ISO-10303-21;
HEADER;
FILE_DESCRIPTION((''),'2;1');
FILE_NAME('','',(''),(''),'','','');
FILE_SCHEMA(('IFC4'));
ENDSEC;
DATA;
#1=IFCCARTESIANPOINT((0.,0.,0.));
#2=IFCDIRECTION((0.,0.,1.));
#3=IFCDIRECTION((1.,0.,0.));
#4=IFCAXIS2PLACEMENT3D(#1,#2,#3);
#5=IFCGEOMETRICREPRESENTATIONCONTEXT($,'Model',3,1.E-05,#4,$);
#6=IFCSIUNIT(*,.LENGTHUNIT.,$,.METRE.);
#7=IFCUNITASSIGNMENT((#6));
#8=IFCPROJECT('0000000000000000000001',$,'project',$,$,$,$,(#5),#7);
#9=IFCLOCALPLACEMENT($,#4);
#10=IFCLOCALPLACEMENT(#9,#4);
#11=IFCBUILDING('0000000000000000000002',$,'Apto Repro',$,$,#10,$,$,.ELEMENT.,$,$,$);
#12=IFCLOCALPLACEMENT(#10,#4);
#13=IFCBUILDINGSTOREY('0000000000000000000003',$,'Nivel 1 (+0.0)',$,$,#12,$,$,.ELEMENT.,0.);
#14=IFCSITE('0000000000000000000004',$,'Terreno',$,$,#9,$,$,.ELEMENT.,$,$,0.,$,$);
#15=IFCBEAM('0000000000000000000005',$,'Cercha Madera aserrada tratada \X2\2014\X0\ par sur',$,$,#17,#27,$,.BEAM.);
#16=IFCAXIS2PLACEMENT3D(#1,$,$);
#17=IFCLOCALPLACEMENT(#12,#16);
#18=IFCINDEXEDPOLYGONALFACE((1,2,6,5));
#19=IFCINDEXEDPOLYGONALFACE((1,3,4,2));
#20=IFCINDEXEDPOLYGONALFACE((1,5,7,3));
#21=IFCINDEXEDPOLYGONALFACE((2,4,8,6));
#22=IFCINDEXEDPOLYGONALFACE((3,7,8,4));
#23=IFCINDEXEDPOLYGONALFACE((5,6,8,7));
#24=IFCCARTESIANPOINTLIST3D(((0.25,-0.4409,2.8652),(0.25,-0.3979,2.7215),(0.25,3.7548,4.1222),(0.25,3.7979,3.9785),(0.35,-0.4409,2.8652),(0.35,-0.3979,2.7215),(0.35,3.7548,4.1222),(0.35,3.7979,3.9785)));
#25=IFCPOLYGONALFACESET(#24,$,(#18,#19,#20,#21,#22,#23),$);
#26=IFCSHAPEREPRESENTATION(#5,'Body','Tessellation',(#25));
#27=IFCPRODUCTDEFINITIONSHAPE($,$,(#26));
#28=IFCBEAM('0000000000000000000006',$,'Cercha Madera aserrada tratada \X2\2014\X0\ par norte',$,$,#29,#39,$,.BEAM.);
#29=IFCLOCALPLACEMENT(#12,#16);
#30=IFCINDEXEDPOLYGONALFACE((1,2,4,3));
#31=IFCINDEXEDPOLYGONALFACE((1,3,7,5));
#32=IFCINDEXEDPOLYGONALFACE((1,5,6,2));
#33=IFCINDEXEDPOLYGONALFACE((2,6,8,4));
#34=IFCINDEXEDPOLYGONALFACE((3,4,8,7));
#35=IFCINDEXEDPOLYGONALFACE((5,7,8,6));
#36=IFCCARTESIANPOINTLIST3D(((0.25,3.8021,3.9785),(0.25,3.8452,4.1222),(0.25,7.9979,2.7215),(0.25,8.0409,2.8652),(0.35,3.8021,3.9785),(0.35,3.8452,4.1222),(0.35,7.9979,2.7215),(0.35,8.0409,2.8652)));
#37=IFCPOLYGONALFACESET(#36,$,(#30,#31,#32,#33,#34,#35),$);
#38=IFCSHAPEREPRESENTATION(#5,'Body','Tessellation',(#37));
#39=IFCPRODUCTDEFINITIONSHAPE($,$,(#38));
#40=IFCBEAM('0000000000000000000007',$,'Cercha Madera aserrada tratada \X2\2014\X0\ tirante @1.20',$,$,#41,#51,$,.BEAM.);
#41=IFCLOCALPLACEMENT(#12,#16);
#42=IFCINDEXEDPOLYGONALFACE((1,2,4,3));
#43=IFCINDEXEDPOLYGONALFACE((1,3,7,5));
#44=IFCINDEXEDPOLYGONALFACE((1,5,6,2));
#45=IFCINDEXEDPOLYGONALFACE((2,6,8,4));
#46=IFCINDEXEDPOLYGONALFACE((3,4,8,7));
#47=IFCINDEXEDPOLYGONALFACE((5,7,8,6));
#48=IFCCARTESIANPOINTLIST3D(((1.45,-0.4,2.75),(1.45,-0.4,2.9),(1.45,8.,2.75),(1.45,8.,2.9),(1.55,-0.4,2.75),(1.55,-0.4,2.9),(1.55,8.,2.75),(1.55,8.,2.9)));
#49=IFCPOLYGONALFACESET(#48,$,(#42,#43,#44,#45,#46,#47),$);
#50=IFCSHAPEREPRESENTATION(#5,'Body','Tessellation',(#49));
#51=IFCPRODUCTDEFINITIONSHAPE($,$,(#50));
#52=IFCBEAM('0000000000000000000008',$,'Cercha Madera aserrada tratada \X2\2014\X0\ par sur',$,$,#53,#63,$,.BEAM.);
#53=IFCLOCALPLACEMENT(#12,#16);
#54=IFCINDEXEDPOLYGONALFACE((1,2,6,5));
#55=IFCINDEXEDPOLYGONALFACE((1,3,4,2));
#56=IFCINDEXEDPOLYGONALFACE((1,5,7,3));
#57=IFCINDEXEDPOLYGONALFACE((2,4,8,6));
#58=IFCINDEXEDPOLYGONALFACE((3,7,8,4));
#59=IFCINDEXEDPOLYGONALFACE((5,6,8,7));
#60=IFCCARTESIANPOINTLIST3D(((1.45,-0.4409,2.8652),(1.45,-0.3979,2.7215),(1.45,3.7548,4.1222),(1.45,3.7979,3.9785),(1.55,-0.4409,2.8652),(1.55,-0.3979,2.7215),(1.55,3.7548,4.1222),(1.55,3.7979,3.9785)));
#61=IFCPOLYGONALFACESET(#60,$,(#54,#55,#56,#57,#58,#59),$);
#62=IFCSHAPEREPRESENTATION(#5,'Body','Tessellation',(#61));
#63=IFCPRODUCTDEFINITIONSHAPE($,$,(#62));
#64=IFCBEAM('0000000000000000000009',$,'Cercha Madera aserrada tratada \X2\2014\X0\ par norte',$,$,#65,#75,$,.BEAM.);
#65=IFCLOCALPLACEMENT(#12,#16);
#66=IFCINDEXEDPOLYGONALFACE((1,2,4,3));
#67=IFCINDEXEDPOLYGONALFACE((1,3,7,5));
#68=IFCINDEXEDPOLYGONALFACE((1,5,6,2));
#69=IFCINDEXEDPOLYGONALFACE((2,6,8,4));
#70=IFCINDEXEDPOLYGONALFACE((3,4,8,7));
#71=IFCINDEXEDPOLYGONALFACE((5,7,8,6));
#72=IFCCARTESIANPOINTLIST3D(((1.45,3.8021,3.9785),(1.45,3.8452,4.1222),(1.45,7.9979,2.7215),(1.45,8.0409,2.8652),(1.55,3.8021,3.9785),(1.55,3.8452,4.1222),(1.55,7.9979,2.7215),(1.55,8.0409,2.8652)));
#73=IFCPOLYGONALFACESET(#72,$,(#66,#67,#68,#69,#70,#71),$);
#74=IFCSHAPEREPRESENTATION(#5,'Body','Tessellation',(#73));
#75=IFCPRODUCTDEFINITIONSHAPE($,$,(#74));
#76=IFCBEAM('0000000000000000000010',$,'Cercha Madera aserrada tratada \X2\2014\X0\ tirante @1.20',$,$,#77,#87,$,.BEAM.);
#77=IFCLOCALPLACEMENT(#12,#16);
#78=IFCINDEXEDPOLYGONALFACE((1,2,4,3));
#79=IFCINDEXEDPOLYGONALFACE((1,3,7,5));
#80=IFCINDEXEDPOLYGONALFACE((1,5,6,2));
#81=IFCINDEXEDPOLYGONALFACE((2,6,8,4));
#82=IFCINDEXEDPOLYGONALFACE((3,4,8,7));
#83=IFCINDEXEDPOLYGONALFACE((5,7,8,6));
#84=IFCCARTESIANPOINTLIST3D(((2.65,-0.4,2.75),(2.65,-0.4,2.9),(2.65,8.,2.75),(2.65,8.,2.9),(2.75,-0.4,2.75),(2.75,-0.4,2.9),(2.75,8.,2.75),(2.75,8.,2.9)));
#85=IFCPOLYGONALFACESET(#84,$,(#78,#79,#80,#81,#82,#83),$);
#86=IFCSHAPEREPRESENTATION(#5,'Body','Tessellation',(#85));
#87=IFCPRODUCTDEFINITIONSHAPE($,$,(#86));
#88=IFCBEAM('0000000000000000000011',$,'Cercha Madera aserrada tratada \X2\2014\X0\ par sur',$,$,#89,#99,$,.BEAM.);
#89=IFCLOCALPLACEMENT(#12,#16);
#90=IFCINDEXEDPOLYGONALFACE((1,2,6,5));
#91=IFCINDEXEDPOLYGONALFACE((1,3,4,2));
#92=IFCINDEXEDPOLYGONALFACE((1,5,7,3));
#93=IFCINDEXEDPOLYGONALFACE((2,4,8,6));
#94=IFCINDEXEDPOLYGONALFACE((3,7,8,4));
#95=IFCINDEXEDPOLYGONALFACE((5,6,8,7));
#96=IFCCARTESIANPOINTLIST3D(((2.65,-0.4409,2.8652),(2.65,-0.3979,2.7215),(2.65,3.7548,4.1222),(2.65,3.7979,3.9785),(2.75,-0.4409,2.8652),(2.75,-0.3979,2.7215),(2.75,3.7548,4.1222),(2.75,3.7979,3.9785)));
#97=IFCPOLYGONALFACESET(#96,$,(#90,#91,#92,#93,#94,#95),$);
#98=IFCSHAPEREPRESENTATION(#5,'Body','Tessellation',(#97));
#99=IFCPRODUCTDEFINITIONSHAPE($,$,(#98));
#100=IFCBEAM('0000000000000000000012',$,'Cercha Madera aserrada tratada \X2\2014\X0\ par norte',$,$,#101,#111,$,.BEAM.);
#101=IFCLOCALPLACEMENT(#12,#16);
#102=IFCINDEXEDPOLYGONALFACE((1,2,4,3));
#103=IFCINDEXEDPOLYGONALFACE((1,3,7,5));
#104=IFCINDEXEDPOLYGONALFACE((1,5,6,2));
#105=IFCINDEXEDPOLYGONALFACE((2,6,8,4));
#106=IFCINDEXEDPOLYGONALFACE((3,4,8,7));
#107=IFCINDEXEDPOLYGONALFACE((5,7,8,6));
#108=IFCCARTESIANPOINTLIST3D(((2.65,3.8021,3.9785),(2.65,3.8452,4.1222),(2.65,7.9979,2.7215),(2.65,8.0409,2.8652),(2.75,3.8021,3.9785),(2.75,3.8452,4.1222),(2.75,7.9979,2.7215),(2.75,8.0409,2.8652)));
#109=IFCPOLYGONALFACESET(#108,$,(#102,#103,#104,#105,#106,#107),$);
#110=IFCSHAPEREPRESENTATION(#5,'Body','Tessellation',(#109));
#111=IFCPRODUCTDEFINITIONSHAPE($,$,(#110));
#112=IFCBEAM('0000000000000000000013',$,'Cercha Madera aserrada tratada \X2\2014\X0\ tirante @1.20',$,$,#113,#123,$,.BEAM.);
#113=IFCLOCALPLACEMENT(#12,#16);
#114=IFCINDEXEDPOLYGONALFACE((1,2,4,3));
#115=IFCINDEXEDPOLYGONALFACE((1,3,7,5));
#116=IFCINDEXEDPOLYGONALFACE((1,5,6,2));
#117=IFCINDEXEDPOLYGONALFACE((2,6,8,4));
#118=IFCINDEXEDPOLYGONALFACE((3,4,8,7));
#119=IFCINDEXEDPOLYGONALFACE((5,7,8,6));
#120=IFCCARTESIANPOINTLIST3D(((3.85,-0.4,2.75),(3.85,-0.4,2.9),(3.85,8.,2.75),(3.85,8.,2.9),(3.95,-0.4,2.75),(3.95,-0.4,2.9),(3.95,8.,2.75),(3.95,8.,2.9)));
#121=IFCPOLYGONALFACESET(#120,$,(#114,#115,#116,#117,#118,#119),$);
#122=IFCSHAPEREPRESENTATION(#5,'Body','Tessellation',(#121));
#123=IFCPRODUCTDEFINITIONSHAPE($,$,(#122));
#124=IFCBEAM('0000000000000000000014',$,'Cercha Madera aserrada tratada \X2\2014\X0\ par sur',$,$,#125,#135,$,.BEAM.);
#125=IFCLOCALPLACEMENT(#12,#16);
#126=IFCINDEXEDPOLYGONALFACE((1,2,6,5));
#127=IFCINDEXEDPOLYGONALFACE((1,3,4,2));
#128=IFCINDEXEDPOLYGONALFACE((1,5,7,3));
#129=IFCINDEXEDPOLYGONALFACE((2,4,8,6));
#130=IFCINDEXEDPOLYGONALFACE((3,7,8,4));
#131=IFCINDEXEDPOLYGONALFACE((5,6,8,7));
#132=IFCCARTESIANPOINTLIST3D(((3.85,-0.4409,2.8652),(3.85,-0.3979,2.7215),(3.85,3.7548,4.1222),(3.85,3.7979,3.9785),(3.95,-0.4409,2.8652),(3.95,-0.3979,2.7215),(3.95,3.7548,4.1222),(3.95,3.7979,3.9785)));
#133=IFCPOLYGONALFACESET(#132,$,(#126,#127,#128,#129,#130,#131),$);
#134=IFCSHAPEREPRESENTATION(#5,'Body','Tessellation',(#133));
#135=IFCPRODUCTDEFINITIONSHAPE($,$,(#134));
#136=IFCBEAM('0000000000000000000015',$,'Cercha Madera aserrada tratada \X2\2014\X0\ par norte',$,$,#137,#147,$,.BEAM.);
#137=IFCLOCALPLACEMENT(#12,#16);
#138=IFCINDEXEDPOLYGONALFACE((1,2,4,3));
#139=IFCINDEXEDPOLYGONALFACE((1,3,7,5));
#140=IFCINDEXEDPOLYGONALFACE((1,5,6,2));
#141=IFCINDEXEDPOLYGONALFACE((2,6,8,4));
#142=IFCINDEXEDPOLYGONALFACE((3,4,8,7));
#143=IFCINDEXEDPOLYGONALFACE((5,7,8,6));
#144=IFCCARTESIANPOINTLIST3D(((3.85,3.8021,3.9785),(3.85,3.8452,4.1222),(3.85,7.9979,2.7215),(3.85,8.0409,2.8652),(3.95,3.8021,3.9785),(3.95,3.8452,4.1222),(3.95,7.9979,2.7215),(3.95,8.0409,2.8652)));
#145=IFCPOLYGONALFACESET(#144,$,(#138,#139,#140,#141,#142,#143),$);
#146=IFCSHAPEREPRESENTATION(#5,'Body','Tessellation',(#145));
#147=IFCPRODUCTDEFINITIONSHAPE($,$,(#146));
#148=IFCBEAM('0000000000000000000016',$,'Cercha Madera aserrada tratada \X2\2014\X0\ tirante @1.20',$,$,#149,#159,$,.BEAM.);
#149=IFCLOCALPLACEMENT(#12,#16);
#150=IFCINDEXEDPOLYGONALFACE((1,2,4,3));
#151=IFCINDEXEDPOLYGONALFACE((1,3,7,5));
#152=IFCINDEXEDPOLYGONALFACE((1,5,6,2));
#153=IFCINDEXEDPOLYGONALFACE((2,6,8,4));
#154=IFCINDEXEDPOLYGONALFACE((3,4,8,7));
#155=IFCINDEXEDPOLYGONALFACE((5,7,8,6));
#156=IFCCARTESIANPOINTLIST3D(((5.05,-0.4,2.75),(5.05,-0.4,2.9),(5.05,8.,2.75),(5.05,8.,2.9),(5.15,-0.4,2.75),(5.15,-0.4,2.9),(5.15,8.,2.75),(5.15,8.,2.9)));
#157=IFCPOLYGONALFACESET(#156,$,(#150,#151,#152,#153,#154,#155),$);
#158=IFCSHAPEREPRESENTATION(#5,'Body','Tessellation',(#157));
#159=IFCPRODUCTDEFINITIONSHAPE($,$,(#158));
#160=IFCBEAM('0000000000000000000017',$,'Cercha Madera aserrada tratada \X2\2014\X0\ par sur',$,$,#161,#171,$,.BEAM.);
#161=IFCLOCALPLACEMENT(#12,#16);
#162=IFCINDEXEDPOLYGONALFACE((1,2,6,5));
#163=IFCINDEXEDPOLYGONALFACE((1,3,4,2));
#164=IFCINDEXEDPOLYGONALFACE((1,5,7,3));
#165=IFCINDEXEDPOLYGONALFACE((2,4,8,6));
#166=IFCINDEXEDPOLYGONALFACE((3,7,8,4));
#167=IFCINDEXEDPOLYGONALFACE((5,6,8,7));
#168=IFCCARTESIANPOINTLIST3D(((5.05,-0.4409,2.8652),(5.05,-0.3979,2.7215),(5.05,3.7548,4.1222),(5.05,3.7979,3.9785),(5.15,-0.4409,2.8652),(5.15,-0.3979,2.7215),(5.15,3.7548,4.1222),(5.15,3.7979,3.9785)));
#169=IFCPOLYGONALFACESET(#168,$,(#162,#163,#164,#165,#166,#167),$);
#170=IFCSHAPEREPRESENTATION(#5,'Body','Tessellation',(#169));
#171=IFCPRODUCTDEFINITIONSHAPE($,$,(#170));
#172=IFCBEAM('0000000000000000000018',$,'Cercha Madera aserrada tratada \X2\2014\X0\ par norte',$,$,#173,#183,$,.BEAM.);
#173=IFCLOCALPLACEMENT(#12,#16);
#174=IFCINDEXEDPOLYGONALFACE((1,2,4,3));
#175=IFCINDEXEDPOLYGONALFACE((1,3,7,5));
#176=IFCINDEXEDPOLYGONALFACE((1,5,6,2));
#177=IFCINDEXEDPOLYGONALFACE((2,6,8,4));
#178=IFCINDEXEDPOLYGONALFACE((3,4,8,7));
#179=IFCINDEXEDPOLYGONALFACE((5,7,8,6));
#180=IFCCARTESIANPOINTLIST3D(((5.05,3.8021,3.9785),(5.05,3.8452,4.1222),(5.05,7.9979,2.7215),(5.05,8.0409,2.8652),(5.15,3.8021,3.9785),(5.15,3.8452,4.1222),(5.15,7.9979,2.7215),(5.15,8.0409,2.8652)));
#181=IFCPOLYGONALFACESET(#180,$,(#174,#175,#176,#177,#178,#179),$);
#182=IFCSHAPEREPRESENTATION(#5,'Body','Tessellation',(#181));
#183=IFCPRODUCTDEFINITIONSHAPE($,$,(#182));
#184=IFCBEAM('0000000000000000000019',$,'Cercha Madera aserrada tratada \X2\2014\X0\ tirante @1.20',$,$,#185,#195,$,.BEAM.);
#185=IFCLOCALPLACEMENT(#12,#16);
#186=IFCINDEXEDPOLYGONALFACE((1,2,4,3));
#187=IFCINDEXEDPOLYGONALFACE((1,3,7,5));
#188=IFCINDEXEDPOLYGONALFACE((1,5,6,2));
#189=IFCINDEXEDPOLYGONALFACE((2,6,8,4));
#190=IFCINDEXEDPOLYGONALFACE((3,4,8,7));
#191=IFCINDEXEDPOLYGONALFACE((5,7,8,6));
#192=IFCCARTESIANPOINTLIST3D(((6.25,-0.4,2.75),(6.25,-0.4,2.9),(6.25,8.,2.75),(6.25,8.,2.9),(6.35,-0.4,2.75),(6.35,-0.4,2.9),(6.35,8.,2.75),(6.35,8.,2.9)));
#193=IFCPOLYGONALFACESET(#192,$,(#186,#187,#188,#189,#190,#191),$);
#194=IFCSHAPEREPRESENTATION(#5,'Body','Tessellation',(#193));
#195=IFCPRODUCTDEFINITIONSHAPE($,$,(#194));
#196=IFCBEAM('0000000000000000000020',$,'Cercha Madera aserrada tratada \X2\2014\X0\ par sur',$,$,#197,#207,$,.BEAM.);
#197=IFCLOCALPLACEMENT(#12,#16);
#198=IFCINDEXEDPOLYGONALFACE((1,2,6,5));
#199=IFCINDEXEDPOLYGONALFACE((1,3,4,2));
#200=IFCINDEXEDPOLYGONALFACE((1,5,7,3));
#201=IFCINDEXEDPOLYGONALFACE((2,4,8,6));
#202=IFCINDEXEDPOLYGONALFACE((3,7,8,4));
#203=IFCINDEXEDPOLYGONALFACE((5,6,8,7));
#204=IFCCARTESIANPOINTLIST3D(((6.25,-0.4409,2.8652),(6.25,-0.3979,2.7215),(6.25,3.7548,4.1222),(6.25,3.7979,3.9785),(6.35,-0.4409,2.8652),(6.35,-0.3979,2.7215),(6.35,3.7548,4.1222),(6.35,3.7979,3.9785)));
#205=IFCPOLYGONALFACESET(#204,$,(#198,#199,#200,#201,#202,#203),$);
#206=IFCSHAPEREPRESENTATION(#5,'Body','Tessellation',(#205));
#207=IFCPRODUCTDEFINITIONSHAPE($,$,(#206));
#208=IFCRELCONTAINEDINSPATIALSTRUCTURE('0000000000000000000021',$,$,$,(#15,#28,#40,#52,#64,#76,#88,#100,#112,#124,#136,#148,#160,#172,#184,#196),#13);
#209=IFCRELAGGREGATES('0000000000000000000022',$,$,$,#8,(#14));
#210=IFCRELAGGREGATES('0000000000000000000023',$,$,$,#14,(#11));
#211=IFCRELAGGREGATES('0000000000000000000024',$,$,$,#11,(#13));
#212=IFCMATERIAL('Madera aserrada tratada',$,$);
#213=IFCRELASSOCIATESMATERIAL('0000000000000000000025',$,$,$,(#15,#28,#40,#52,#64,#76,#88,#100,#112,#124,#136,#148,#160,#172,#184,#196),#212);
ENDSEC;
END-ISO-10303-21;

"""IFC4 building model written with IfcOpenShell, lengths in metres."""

from ifc_helpers import new_model, si_unit, frame, origin_with_axes, origin_2d_with_axis, place, context, project, spatial, rectangle, extrude, material, element, save


model = new_model("IFC4")

# Units and contexts
model_context = context("Model", 3, precision=1e-05, world=origin_with_axes())
ifc_project = project(units=[si_unit("LENGTHUNIT", "METRE")], contexts=[model_context])

# Site, building, storey
site_placement = place(None, origin_with_axes())
site = spatial("IfcSite", under=ifc_project, at=site_placement, Name="Terreno", CompositionType="ELEMENT", RefElevation=0.0)
building_placement = place(site_placement, origin_with_axes())
building = spatial("IfcBuilding", under=site, at=building_placement, Name="Apto Repro", CompositionType="ELEMENT")
storey_placement = place(building_placement, origin_with_axes())
storey = spatial("IfcBuildingStorey", under=building, at=storey_placement, Name="Nivel 1 (+0.0)", CompositionType="ELEMENT", Elevation=0.0)

# Beams
ifc_material = material(Name="Madera aserrada tratada")
beam_1_placement = place(storey_placement, origin_with_axes())
element("IfcBeam", 1, at=beam_1_placement, inside=storey, material=ifc_material, Name="Cercha Madera aserrada tratada — par sur", PredefinedType="BEAM", context=model_context, shape_type="SweptSolid", body=[
    extrude(rectangle(XDim=0.1, YDim=4.38, at=origin_2d_with_axis()), frame((0.3, 1.7, 3.35), z_axis=(0.0, -0.287, 0.958), x_axis=(1.0, 0.0, 0.0)), (0.0, 0.0, 1.0), 0.15),
])
beam_2_placement = place(storey_placement, origin_with_axes())
element("IfcBeam", 2, at=beam_2_placement, inside=storey, material=ifc_material, Name="Cercha Madera aserrada tratada — par norte", PredefinedType="BEAM", context=model_context, shape_type="SweptSolid", body=[
    extrude(rectangle(XDim=0.1, YDim=4.38, at=origin_2d_with_axis()), frame((0.3, 5.9, 3.35), z_axis=(0.0, 0.287, 0.958), x_axis=(1.0, 0.0, 0.0)), (0.0, 0.0, 1.0), 0.15),
])
beam_3_placement = place(storey_placement, origin_with_axes())
element("IfcBeam", 3, at=beam_3_placement, inside=storey, material=ifc_material, Name="Cercha Madera aserrada tratada — tirante @1.20", PredefinedType="BEAM", context=model_context, shape_type="SweptSolid", body=[
    extrude(rectangle(XDim=8.4, YDim=0.1, at=origin_2d_with_axis()), frame((1.5, 3.8, 2.75), z_axis=(0.0, 0.0, 1.0), x_axis=(0.0, 1.0, 0.0)), (0.0, 0.0, 1.0), 0.15),
])
beam_4_placement = place(storey_placement, origin_with_axes())
element("IfcBeam", 4, at=beam_4_placement, inside=storey, material=ifc_material, Name="Cercha Madera aserrada tratada — par sur", PredefinedType="BEAM", context=model_context, shape_type="SweptSolid", body=[
    extrude(rectangle(XDim=0.1, YDim=4.38, at=origin_2d_with_axis()), frame((1.5, 1.7, 3.35), z_axis=(0.0, -0.287, 0.958), x_axis=(1.0, 0.0, 0.0)), (0.0, 0.0, 1.0), 0.15),
])
beam_5_placement = place(storey_placement, origin_with_axes())
element("IfcBeam", 5, at=beam_5_placement, inside=storey, material=ifc_material, Name="Cercha Madera aserrada tratada — par norte", PredefinedType="BEAM", context=model_context, shape_type="SweptSolid", body=[
    extrude(rectangle(XDim=0.1, YDim=4.38, at=origin_2d_with_axis()), frame((1.5, 5.9, 3.35), z_axis=(0.0, 0.287, 0.958), x_axis=(1.0, 0.0, 0.0)), (0.0, 0.0, 1.0), 0.15),
])
beam_6_placement = place(storey_placement, origin_with_axes())
element("IfcBeam", 6, at=beam_6_placement, inside=storey, material=ifc_material, Name="Cercha Madera aserrada tratada — tirante @1.20", PredefinedType="BEAM", context=model_context, shape_type="SweptSolid", body=[
    extrude(rectangle(XDim=8.4, YDim=0.1, at=origin_2d_with_axis()), frame((2.7, 3.8, 2.75), z_axis=(0.0, 0.0, 1.0), x_axis=(0.0, 1.0, 0.0)), (0.0, 0.0, 1.0), 0.15),
])
beam_7_placement = place(storey_placement, origin_with_axes())
element("IfcBeam", 7, at=beam_7_placement, inside=storey, material=ifc_material, Name="Cercha Madera aserrada tratada — par sur", PredefinedType="BEAM", context=model_context, shape_type="SweptSolid", body=[
    extrude(rectangle(XDim=0.1, YDim=4.38, at=origin_2d_with_axis()), frame((2.7, 1.7, 3.35), z_axis=(0.0, -0.287, 0.958), x_axis=(1.0, 0.0, 0.0)), (0.0, 0.0, 1.0), 0.15),
])
beam_8_placement = place(storey_placement, origin_with_axes())
element("IfcBeam", 8, at=beam_8_placement, inside=storey, material=ifc_material, Name="Cercha Madera aserrada tratada — par norte", PredefinedType="BEAM", context=model_context, shape_type="SweptSolid", body=[
    extrude(rectangle(XDim=0.1, YDim=4.38, at=origin_2d_with_axis()), frame((2.7, 5.9, 3.35), z_axis=(0.0, 0.287, 0.958), x_axis=(1.0, 0.0, 0.0)), (0.0, 0.0, 1.0), 0.15),
])
beam_9_placement = place(storey_placement, origin_with_axes())
element("IfcBeam", 9, at=beam_9_placement, inside=storey, material=ifc_material, Name="Cercha Madera aserrada tratada — tirante @1.20", PredefinedType="BEAM", context=model_context, shape_type="SweptSolid", body=[
    extrude(rectangle(XDim=8.4, YDim=0.1, at=origin_2d_with_axis()), frame((3.9, 3.8, 2.75), z_axis=(0.0, 0.0, 1.0), x_axis=(0.0, 1.0, 0.0)), (0.0, 0.0, 1.0), 0.15),
])
beam_10_placement = place(storey_placement, origin_with_axes())
element("IfcBeam", 10, at=beam_10_placement, inside=storey, material=ifc_material, Name="Cercha Madera aserrada tratada — par sur", PredefinedType="BEAM", context=model_context, shape_type="SweptSolid", body=[
    extrude(rectangle(XDim=0.1, YDim=4.38, at=origin_2d_with_axis()), frame((3.9, 1.7, 3.35), z_axis=(0.0, -0.287, 0.958), x_axis=(1.0, 0.0, 0.0)), (0.0, 0.0, 1.0), 0.15),
])
beam_11_placement = place(storey_placement, origin_with_axes())
element("IfcBeam", 11, at=beam_11_placement, inside=storey, material=ifc_material, Name="Cercha Madera aserrada tratada — par norte", PredefinedType="BEAM", context=model_context, shape_type="SweptSolid", body=[
    extrude(rectangle(XDim=0.1, YDim=4.38, at=origin_2d_with_axis()), frame((3.9, 5.9, 3.35), z_axis=(0.0, 0.287, 0.958), x_axis=(1.0, 0.0, 0.0)), (0.0, 0.0, 1.0), 0.15),
])
beam_12_placement = place(storey_placement, origin_with_axes())
element("IfcBeam", 12, at=beam_12_placement, inside=storey, material=ifc_material, Name="Cercha Madera aserrada tratada — tirante @1.20", PredefinedType="BEAM", context=model_context, shape_type="SweptSolid", body=[
    extrude(rectangle(XDim=8.4, YDim=0.1, at=origin_2d_with_axis()), frame((5.1, 3.8, 2.75), z_axis=(0.0, 0.0, 1.0), x_axis=(0.0, 1.0, 0.0)), (0.0, 0.0, 1.0), 0.15),
])
beam_13_placement = place(storey_placement, origin_with_axes())
element("IfcBeam", 13, at=beam_13_placement, inside=storey, material=ifc_material, Name="Cercha Madera aserrada tratada — par sur", PredefinedType="BEAM", context=model_context, shape_type="SweptSolid", body=[
    extrude(rectangle(XDim=0.1, YDim=4.38, at=origin_2d_with_axis()), frame((5.1, 1.7, 3.35), z_axis=(0.0, -0.287, 0.958), x_axis=(1.0, 0.0, 0.0)), (0.0, 0.0, 1.0), 0.15),
])
beam_14_placement = place(storey_placement, origin_with_axes())
element("IfcBeam", 14, at=beam_14_placement, inside=storey, material=ifc_material, Name="Cercha Madera aserrada tratada — par norte", PredefinedType="BEAM", context=model_context, shape_type="SweptSolid", body=[
    extrude(rectangle(XDim=0.1, YDim=4.38, at=origin_2d_with_axis()), frame((5.1, 5.9, 3.35), z_axis=(0.0, 0.287, 0.958), x_axis=(1.0, 0.0, 0.0)), (0.0, 0.0, 1.0), 0.15),
])
beam_15_placement = place(storey_placement, origin_with_axes())
element("IfcBeam", 15, at=beam_15_placement, inside=storey, material=ifc_material, Name="Cercha Madera aserrada tratada — tirante @1.20", PredefinedType="BEAM", context=model_context, shape_type="SweptSolid", body=[
    extrude(rectangle(XDim=8.4, YDim=0.1, at=origin_2d_with_axis()), frame((6.3, 3.8, 2.75), z_axis=(0.0, 0.0, 1.0), x_axis=(0.0, 1.0, 0.0)), (0.0, 0.0, 1.0), 0.15),
])
beam_16_placement = place(storey_placement, origin_with_axes())
element("IfcBeam", 16, at=beam_16_placement, inside=storey, material=ifc_material, Name="Cercha Madera aserrada tratada — par sur", PredefinedType="BEAM", context=model_context, shape_type="SweptSolid", body=[
    extrude(rectangle(XDim=0.1, YDim=4.38, at=origin_2d_with_axis()), frame((6.3, 1.7, 3.35), z_axis=(0.0, -0.287, 0.958), x_axis=(1.0, 0.0, 0.0)), (0.0, 0.0, 1.0), 0.15),
])

save(model, "model.ifc")
